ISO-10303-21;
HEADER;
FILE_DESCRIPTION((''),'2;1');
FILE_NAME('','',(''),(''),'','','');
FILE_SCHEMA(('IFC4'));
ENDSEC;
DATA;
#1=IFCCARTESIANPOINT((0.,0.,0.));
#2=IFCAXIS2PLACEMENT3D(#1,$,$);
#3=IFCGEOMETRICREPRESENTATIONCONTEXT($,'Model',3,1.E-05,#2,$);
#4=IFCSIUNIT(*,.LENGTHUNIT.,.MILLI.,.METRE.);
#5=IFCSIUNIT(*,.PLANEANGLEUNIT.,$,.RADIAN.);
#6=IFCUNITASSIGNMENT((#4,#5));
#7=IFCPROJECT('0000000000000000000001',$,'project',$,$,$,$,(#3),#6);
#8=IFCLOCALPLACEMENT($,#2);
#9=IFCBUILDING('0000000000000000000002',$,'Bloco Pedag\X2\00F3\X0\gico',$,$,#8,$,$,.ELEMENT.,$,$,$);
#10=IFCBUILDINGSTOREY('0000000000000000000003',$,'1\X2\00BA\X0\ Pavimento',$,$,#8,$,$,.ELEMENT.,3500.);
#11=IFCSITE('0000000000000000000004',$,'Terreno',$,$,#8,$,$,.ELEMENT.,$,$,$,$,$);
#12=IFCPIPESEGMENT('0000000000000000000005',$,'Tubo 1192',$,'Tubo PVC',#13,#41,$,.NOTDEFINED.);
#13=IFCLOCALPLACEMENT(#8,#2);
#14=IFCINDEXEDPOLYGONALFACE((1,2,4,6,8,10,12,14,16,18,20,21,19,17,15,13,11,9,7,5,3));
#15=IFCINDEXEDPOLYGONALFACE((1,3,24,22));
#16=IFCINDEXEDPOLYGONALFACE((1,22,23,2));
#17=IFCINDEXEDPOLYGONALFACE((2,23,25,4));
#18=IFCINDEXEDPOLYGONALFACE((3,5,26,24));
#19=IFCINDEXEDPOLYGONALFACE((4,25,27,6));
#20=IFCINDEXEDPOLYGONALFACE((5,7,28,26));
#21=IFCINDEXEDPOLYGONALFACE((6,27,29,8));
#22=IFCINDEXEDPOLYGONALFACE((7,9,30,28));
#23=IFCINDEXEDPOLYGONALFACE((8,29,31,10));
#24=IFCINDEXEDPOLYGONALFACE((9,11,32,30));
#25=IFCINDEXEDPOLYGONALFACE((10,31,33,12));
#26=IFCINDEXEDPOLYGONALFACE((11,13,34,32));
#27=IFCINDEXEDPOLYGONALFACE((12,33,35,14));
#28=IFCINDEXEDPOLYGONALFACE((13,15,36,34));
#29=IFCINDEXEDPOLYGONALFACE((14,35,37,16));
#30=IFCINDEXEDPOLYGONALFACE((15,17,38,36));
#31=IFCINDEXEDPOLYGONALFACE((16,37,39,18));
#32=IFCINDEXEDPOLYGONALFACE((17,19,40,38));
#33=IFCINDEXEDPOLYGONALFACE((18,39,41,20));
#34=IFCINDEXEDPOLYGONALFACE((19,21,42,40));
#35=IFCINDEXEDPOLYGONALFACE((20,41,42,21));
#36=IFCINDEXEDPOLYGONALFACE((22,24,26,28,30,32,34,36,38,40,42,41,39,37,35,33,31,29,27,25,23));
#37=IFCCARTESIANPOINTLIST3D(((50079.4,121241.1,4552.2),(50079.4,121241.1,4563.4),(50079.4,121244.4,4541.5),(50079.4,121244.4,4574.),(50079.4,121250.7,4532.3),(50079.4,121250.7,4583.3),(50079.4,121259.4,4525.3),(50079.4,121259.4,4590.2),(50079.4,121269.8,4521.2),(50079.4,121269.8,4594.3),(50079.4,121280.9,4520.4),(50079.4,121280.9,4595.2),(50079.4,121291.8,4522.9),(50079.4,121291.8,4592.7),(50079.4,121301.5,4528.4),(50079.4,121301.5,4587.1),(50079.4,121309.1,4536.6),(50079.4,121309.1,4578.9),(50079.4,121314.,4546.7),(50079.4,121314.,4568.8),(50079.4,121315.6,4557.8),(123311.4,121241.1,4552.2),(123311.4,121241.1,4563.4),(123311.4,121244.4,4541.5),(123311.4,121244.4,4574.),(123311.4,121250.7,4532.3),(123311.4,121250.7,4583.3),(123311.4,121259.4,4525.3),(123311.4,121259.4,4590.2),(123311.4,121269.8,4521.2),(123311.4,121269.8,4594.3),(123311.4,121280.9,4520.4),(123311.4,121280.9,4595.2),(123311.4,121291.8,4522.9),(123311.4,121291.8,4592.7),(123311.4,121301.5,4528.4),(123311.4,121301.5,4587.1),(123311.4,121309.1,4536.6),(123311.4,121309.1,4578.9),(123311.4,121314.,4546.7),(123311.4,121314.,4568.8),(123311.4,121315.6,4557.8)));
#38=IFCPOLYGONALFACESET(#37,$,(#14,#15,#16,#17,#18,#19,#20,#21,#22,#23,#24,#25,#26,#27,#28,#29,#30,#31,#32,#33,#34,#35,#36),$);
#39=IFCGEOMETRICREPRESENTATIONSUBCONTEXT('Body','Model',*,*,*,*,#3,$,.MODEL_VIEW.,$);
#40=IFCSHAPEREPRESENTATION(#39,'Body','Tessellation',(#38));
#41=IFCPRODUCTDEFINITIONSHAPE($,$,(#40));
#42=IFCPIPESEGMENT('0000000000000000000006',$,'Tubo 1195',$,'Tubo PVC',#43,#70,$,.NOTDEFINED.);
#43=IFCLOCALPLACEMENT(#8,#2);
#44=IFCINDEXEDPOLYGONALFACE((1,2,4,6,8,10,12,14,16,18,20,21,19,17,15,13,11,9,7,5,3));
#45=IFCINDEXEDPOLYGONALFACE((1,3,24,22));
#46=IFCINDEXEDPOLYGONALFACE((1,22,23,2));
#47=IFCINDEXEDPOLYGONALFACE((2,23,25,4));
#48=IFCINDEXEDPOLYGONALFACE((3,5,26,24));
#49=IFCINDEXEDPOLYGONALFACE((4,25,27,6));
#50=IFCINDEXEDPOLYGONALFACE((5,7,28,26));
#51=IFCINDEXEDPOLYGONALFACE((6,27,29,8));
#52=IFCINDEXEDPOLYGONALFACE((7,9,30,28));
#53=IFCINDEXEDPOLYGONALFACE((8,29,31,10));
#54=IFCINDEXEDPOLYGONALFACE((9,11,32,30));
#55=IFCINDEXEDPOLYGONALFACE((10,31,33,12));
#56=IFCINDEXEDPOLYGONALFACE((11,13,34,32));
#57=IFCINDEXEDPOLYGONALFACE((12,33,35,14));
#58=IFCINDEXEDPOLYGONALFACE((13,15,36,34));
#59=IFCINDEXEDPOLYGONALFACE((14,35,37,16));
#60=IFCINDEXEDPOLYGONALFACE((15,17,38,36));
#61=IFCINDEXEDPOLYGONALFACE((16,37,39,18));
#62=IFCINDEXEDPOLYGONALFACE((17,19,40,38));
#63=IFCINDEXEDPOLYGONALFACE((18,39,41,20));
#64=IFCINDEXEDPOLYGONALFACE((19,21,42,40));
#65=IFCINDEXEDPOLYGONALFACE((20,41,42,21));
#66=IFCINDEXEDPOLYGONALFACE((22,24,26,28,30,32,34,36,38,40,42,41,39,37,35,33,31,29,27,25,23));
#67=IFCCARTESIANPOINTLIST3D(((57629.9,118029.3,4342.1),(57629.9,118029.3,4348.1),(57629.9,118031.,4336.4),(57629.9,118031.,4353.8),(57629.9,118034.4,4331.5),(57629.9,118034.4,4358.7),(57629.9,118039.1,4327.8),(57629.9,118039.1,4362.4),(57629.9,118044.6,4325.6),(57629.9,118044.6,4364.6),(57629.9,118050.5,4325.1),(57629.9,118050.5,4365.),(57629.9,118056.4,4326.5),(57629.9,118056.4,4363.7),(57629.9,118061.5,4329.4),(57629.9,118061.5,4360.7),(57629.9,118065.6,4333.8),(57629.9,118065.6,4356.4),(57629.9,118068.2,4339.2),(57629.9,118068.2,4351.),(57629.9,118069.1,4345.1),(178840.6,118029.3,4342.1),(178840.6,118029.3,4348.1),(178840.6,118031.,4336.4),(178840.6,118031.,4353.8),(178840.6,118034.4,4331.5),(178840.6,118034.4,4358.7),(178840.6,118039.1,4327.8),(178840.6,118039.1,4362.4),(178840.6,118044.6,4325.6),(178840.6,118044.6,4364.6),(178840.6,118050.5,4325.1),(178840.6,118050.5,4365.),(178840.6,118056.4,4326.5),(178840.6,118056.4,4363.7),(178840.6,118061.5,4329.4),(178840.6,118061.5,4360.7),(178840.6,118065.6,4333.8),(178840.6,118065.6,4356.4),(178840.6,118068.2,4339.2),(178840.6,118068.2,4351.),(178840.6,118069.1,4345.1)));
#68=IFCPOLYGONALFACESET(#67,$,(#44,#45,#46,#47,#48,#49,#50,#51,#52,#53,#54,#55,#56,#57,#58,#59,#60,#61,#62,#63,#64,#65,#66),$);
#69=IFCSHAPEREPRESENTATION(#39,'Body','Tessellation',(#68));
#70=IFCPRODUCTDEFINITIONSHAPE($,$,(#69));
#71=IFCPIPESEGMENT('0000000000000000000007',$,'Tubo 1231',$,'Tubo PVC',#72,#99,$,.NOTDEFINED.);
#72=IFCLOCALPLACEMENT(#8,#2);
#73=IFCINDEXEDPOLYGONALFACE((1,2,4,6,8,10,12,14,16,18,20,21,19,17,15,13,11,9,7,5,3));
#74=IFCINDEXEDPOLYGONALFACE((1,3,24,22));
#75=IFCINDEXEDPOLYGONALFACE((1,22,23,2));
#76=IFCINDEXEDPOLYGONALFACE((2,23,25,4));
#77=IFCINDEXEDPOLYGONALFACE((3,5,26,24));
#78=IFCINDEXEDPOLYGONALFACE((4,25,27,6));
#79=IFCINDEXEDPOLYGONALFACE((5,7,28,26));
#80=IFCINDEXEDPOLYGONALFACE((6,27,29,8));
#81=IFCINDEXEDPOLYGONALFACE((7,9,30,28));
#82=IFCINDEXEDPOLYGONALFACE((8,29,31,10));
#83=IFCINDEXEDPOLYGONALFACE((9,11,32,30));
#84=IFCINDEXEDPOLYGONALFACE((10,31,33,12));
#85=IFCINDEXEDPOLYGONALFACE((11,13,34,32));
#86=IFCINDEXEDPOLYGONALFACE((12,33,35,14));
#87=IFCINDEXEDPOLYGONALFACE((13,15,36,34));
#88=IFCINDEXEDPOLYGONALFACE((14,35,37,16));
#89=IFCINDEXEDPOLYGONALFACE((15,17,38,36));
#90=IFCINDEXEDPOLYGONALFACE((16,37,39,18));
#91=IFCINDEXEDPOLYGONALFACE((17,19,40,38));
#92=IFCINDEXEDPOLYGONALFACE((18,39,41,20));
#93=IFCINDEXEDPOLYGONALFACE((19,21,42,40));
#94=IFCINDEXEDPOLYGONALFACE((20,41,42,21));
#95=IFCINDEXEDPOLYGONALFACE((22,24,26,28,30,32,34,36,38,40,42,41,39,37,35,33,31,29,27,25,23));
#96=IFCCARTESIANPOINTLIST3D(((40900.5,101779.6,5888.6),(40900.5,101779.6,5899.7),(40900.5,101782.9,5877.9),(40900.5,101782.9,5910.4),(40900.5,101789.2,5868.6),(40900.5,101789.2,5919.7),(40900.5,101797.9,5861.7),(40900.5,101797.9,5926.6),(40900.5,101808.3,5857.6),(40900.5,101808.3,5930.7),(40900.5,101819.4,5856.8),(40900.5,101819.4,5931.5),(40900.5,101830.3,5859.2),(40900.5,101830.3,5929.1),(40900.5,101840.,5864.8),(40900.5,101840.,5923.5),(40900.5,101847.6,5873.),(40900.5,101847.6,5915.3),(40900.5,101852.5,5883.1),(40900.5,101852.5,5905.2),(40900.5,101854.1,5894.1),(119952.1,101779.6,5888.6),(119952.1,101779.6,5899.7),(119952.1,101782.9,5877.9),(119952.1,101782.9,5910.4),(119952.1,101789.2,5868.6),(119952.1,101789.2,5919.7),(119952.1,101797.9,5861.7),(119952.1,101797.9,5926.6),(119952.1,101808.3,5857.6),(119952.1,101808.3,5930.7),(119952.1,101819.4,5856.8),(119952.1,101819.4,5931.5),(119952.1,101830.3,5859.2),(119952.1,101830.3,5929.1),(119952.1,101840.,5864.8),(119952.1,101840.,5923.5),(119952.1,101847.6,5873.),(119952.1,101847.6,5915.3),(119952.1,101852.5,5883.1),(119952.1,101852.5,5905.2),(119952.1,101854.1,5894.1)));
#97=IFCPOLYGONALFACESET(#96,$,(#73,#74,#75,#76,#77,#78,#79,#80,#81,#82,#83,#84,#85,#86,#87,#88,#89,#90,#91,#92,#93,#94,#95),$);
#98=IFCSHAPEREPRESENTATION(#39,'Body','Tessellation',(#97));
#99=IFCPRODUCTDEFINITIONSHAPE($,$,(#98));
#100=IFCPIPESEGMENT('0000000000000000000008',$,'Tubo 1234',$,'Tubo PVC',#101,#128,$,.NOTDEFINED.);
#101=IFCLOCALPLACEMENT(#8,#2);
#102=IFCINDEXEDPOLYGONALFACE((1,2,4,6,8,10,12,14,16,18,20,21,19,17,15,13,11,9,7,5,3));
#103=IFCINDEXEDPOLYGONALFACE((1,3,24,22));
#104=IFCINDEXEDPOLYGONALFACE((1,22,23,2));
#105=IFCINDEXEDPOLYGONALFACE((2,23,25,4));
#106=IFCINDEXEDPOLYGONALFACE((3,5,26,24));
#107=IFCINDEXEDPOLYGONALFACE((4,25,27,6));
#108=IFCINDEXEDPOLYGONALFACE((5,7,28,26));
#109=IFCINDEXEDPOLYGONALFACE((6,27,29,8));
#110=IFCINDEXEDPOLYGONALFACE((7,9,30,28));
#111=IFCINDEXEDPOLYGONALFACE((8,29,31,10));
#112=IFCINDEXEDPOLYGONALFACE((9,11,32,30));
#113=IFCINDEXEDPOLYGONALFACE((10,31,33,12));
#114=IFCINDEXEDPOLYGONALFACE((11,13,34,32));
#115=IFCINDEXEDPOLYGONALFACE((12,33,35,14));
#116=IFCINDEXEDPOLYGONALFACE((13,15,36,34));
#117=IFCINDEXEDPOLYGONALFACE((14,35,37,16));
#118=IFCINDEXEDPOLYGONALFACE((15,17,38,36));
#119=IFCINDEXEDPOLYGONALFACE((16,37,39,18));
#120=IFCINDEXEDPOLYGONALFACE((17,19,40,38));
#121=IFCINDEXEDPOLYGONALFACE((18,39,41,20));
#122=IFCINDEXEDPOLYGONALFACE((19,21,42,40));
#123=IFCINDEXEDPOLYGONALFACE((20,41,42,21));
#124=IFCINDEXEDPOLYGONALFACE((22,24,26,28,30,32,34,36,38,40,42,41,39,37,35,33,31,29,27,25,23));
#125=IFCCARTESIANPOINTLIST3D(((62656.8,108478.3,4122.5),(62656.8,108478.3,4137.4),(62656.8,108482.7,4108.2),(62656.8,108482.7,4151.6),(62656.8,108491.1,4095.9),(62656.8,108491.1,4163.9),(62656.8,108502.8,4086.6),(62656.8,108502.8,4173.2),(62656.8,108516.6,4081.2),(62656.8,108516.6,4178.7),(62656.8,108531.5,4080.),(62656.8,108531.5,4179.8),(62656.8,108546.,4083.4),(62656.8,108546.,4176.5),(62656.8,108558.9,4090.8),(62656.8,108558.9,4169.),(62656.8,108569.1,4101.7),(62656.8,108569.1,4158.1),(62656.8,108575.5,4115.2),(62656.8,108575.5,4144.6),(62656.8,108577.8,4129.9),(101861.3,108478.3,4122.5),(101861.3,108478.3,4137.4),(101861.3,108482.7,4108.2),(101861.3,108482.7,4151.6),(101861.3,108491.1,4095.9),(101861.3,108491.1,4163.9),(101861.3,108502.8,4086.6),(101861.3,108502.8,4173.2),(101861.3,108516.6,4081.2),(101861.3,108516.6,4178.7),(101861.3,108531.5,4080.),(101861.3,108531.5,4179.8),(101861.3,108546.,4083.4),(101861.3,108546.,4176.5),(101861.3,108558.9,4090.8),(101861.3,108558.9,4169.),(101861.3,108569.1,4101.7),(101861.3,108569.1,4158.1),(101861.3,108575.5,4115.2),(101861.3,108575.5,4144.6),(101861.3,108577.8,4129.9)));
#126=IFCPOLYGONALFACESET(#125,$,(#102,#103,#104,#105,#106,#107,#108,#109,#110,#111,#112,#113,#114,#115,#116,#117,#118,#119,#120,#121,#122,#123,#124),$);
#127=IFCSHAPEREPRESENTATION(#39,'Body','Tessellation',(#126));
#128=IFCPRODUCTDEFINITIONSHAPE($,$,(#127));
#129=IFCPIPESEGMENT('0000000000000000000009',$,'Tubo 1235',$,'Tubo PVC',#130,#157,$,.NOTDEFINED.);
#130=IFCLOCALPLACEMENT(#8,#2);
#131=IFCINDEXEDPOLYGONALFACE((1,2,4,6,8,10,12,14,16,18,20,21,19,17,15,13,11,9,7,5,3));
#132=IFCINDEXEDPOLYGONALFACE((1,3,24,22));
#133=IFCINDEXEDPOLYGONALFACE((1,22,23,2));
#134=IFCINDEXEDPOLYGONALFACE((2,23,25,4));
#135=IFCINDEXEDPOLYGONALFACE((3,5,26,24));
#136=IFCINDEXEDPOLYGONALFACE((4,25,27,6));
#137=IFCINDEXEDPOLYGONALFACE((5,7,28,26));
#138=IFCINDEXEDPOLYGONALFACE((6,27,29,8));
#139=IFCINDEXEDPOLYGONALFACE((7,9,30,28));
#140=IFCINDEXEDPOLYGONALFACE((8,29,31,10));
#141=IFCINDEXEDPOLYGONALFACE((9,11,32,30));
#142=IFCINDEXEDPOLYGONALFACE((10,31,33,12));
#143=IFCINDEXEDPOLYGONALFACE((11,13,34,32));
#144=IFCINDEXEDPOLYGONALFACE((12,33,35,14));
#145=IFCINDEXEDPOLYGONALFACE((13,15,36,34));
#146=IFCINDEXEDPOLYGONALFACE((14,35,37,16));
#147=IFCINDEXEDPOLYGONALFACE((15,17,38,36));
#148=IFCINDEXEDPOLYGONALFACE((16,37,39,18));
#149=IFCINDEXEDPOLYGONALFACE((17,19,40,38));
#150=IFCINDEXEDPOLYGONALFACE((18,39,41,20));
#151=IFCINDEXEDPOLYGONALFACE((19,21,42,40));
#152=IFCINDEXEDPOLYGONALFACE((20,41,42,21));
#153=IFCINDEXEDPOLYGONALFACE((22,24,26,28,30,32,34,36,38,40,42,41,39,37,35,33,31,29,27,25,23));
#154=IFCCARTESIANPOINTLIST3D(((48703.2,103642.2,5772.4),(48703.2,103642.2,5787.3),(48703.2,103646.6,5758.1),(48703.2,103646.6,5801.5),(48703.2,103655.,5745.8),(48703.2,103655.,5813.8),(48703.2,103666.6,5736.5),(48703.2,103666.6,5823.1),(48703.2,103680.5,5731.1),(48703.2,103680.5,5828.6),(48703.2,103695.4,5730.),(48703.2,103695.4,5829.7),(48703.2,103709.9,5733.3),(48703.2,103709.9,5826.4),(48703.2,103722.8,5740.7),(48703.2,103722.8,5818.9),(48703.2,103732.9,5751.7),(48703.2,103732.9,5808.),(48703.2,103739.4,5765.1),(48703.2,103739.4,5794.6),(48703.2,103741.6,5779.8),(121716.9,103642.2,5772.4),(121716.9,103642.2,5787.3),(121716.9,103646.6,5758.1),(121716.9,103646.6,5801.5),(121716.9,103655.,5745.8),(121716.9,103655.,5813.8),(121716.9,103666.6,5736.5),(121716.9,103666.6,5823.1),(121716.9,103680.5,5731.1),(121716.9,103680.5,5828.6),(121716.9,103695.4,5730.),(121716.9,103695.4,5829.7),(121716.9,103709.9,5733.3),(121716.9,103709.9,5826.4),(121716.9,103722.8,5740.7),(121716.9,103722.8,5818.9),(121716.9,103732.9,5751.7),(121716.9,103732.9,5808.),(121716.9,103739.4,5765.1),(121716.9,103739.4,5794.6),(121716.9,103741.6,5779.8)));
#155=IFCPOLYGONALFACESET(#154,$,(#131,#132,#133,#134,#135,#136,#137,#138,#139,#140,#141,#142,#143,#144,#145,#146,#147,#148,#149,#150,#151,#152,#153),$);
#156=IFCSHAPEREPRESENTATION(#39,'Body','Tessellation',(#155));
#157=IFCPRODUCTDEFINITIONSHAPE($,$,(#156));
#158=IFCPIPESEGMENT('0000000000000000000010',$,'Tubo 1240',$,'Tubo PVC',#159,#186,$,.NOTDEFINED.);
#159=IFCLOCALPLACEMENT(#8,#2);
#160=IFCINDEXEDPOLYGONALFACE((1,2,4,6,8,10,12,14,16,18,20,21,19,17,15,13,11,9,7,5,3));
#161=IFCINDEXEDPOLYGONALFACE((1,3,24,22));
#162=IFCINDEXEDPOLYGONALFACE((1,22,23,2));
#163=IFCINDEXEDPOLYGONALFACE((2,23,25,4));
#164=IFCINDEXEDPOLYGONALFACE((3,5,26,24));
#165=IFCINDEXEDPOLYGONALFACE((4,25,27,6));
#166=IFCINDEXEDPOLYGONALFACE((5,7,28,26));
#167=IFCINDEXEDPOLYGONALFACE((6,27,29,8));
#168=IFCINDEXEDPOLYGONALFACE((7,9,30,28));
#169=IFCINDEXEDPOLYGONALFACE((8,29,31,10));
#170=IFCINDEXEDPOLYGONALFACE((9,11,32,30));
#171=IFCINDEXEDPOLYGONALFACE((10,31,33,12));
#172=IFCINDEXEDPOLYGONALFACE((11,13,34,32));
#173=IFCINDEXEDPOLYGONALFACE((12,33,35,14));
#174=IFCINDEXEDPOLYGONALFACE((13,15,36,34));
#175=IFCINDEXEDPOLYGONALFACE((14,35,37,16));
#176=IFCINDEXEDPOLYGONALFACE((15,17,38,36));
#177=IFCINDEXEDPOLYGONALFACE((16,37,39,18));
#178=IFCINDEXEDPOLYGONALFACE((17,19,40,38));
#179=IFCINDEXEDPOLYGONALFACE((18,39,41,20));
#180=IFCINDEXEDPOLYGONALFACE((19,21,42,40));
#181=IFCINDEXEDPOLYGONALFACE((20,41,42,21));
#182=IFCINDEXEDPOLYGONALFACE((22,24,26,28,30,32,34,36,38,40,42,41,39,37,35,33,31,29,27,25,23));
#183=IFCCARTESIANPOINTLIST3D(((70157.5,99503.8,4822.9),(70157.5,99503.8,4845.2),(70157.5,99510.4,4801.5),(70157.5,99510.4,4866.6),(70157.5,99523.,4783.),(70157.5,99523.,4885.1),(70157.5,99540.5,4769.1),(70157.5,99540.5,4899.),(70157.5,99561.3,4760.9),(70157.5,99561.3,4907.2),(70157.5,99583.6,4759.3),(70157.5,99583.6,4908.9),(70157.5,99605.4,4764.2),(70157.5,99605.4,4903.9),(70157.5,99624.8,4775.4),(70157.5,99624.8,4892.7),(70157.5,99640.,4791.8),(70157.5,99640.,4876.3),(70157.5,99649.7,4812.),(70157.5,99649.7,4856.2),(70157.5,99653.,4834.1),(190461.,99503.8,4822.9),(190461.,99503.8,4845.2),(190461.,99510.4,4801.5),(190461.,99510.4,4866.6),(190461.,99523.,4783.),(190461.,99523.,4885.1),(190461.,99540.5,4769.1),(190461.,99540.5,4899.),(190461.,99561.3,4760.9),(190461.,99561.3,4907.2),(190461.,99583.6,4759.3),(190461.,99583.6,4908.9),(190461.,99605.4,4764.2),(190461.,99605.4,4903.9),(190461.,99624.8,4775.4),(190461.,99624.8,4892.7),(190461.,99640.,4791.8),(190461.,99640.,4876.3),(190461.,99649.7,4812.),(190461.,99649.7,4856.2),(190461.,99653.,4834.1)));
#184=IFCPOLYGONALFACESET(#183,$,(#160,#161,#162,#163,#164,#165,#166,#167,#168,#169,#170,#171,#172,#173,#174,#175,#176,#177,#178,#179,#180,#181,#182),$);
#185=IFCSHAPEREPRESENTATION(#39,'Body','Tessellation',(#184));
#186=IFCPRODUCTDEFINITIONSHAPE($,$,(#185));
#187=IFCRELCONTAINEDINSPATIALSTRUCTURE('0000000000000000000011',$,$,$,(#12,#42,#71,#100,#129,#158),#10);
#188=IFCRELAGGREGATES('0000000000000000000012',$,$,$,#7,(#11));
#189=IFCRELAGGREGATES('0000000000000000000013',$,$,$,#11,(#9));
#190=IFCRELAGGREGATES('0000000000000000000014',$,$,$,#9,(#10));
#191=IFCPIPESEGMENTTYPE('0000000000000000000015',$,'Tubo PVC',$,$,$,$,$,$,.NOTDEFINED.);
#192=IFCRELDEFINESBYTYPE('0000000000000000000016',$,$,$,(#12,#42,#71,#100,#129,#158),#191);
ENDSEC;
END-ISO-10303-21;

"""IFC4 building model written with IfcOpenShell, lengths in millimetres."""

from ifc_helpers import new_model, si_unit, frame, origin, origin_2d, place, context, subcontext, project, spatial, circle, extrude, type_object, element, save


model = new_model("IFC4")

# Units and contexts
model_context = context("Model", 3, precision=1e-05, world=origin())
body_context = subcontext(model_context, "Body", "Model", "MODEL_VIEW")
ifc_project = project(units=[si_unit("LENGTHUNIT", "METRE", prefix="MILLI"), si_unit("PLANEANGLEUNIT", "RADIAN")], contexts=[model_context])

# Site, building, storey
placement = place(None, origin())
site = spatial("IfcSite", under=ifc_project, at=placement, Name="Terreno", CompositionType="ELEMENT")
building = spatial("IfcBuilding", under=site, at=placement, Name="Bloco Pedagógico", CompositionType="ELEMENT")
storey = spatial("IfcBuildingStorey", under=building, at=placement, Name="1º Pavimento", CompositionType="ELEMENT", Elevation=3500.0)

# Pipe segments
pipe_segment_type = type_object("IfcPipeSegmentType", Name="Tubo PVC", PredefinedType="NOTDEFINED")
pipe_segment_1_placement = place(None, frame((50079.4, 121278.1, 4557.8), z_axis=(1.0, 0.0, 0.0), x_axis=(0.0, 1.0, 0.0)))
element("IfcPipeSegment", 1, at=pipe_segment_1_placement, inside=storey, type_object=pipe_segment_type, Name="Tubo 1192", ObjectType="Tubo PVC", PredefinedType="NOTDEFINED", context=body_context, shape_type="SweptSolid", body=[
    extrude(circle(Radius=37.5, at=origin_2d()), None, (0.0, 0.0, 1.0), 73232.0),
])
pipe_segment_2_placement = place(None, frame((57629.9, 118049.1, 4345.1), z_axis=(1.0, 0.0, 0.0), x_axis=(0.0, 1.0, 0.0)))
element("IfcPipeSegment", 2, at=pipe_segment_2_placement, inside=storey, type_object=pipe_segment_type, Name="Tubo 1195", ObjectType="Tubo PVC", PredefinedType="NOTDEFINED", context=body_context, shape_type="SweptSolid", body=[
    extrude(circle(Radius=20.0, at=origin_2d()), None, (0.0, 0.0, 1.0), 121210.7),
])
pipe_segment_3_placement = place(None, frame((40900.5, 101816.6, 5894.1), z_axis=(1.0, 0.0, 0.0), x_axis=(0.0, 1.0, 0.0)))
element("IfcPipeSegment", 3, at=pipe_segment_3_placement, inside=storey, type_object=pipe_segment_type, Name="Tubo 1231", ObjectType="Tubo PVC", PredefinedType="NOTDEFINED", context=body_context, shape_type="SweptSolid", body=[
    extrude(circle(Radius=37.5, at=origin_2d()), None, (0.0, 0.0, 1.0), 79051.6),
])
pipe_segment_4_placement = place(None, frame((62656.8, 108527.8, 4129.9), z_axis=(1.0, 0.0, 0.0), x_axis=(0.0, 1.0, 0.0)))
element("IfcPipeSegment", 4, at=pipe_segment_4_placement, inside=storey, type_object=pipe_segment_type, Name="Tubo 1234", ObjectType="Tubo PVC", PredefinedType="NOTDEFINED", context=body_context, shape_type="SweptSolid", body=[
    extrude(circle(Radius=50.0, at=origin_2d()), None, (0.0, 0.0, 1.0), 39204.5),
])
pipe_segment_5_placement = place(None, frame((48703.2, 103691.6, 5779.8), z_axis=(1.0, 0.0, 0.0), x_axis=(0.0, 1.0, 0.0)))
element("IfcPipeSegment", 5, at=pipe_segment_5_placement, inside=storey, type_object=pipe_segment_type, Name="Tubo 1235", ObjectType="Tubo PVC", PredefinedType="NOTDEFINED", context=body_context, shape_type="SweptSolid", body=[
    extrude(circle(Radius=50.0, at=origin_2d()), None, (0.0, 0.0, 1.0), 73013.7),
])
pipe_segment_6_placement = place(None, frame((70157.5, 99578.0, 4834.1), z_axis=(1.0, 0.0, 0.0), x_axis=(0.0, 1.0, 0.0)))
element("IfcPipeSegment", 6, at=pipe_segment_6_placement, inside=storey, type_object=pipe_segment_type, Name="Tubo 1240", ObjectType="Tubo PVC", PredefinedType="NOTDEFINED", context=body_context, shape_type="SweptSolid", body=[
    extrude(circle(Radius=75.0, at=origin_2d()), None, (0.0, 0.0, 1.0), 120303.5),
])

save(model, "model.ifc")
